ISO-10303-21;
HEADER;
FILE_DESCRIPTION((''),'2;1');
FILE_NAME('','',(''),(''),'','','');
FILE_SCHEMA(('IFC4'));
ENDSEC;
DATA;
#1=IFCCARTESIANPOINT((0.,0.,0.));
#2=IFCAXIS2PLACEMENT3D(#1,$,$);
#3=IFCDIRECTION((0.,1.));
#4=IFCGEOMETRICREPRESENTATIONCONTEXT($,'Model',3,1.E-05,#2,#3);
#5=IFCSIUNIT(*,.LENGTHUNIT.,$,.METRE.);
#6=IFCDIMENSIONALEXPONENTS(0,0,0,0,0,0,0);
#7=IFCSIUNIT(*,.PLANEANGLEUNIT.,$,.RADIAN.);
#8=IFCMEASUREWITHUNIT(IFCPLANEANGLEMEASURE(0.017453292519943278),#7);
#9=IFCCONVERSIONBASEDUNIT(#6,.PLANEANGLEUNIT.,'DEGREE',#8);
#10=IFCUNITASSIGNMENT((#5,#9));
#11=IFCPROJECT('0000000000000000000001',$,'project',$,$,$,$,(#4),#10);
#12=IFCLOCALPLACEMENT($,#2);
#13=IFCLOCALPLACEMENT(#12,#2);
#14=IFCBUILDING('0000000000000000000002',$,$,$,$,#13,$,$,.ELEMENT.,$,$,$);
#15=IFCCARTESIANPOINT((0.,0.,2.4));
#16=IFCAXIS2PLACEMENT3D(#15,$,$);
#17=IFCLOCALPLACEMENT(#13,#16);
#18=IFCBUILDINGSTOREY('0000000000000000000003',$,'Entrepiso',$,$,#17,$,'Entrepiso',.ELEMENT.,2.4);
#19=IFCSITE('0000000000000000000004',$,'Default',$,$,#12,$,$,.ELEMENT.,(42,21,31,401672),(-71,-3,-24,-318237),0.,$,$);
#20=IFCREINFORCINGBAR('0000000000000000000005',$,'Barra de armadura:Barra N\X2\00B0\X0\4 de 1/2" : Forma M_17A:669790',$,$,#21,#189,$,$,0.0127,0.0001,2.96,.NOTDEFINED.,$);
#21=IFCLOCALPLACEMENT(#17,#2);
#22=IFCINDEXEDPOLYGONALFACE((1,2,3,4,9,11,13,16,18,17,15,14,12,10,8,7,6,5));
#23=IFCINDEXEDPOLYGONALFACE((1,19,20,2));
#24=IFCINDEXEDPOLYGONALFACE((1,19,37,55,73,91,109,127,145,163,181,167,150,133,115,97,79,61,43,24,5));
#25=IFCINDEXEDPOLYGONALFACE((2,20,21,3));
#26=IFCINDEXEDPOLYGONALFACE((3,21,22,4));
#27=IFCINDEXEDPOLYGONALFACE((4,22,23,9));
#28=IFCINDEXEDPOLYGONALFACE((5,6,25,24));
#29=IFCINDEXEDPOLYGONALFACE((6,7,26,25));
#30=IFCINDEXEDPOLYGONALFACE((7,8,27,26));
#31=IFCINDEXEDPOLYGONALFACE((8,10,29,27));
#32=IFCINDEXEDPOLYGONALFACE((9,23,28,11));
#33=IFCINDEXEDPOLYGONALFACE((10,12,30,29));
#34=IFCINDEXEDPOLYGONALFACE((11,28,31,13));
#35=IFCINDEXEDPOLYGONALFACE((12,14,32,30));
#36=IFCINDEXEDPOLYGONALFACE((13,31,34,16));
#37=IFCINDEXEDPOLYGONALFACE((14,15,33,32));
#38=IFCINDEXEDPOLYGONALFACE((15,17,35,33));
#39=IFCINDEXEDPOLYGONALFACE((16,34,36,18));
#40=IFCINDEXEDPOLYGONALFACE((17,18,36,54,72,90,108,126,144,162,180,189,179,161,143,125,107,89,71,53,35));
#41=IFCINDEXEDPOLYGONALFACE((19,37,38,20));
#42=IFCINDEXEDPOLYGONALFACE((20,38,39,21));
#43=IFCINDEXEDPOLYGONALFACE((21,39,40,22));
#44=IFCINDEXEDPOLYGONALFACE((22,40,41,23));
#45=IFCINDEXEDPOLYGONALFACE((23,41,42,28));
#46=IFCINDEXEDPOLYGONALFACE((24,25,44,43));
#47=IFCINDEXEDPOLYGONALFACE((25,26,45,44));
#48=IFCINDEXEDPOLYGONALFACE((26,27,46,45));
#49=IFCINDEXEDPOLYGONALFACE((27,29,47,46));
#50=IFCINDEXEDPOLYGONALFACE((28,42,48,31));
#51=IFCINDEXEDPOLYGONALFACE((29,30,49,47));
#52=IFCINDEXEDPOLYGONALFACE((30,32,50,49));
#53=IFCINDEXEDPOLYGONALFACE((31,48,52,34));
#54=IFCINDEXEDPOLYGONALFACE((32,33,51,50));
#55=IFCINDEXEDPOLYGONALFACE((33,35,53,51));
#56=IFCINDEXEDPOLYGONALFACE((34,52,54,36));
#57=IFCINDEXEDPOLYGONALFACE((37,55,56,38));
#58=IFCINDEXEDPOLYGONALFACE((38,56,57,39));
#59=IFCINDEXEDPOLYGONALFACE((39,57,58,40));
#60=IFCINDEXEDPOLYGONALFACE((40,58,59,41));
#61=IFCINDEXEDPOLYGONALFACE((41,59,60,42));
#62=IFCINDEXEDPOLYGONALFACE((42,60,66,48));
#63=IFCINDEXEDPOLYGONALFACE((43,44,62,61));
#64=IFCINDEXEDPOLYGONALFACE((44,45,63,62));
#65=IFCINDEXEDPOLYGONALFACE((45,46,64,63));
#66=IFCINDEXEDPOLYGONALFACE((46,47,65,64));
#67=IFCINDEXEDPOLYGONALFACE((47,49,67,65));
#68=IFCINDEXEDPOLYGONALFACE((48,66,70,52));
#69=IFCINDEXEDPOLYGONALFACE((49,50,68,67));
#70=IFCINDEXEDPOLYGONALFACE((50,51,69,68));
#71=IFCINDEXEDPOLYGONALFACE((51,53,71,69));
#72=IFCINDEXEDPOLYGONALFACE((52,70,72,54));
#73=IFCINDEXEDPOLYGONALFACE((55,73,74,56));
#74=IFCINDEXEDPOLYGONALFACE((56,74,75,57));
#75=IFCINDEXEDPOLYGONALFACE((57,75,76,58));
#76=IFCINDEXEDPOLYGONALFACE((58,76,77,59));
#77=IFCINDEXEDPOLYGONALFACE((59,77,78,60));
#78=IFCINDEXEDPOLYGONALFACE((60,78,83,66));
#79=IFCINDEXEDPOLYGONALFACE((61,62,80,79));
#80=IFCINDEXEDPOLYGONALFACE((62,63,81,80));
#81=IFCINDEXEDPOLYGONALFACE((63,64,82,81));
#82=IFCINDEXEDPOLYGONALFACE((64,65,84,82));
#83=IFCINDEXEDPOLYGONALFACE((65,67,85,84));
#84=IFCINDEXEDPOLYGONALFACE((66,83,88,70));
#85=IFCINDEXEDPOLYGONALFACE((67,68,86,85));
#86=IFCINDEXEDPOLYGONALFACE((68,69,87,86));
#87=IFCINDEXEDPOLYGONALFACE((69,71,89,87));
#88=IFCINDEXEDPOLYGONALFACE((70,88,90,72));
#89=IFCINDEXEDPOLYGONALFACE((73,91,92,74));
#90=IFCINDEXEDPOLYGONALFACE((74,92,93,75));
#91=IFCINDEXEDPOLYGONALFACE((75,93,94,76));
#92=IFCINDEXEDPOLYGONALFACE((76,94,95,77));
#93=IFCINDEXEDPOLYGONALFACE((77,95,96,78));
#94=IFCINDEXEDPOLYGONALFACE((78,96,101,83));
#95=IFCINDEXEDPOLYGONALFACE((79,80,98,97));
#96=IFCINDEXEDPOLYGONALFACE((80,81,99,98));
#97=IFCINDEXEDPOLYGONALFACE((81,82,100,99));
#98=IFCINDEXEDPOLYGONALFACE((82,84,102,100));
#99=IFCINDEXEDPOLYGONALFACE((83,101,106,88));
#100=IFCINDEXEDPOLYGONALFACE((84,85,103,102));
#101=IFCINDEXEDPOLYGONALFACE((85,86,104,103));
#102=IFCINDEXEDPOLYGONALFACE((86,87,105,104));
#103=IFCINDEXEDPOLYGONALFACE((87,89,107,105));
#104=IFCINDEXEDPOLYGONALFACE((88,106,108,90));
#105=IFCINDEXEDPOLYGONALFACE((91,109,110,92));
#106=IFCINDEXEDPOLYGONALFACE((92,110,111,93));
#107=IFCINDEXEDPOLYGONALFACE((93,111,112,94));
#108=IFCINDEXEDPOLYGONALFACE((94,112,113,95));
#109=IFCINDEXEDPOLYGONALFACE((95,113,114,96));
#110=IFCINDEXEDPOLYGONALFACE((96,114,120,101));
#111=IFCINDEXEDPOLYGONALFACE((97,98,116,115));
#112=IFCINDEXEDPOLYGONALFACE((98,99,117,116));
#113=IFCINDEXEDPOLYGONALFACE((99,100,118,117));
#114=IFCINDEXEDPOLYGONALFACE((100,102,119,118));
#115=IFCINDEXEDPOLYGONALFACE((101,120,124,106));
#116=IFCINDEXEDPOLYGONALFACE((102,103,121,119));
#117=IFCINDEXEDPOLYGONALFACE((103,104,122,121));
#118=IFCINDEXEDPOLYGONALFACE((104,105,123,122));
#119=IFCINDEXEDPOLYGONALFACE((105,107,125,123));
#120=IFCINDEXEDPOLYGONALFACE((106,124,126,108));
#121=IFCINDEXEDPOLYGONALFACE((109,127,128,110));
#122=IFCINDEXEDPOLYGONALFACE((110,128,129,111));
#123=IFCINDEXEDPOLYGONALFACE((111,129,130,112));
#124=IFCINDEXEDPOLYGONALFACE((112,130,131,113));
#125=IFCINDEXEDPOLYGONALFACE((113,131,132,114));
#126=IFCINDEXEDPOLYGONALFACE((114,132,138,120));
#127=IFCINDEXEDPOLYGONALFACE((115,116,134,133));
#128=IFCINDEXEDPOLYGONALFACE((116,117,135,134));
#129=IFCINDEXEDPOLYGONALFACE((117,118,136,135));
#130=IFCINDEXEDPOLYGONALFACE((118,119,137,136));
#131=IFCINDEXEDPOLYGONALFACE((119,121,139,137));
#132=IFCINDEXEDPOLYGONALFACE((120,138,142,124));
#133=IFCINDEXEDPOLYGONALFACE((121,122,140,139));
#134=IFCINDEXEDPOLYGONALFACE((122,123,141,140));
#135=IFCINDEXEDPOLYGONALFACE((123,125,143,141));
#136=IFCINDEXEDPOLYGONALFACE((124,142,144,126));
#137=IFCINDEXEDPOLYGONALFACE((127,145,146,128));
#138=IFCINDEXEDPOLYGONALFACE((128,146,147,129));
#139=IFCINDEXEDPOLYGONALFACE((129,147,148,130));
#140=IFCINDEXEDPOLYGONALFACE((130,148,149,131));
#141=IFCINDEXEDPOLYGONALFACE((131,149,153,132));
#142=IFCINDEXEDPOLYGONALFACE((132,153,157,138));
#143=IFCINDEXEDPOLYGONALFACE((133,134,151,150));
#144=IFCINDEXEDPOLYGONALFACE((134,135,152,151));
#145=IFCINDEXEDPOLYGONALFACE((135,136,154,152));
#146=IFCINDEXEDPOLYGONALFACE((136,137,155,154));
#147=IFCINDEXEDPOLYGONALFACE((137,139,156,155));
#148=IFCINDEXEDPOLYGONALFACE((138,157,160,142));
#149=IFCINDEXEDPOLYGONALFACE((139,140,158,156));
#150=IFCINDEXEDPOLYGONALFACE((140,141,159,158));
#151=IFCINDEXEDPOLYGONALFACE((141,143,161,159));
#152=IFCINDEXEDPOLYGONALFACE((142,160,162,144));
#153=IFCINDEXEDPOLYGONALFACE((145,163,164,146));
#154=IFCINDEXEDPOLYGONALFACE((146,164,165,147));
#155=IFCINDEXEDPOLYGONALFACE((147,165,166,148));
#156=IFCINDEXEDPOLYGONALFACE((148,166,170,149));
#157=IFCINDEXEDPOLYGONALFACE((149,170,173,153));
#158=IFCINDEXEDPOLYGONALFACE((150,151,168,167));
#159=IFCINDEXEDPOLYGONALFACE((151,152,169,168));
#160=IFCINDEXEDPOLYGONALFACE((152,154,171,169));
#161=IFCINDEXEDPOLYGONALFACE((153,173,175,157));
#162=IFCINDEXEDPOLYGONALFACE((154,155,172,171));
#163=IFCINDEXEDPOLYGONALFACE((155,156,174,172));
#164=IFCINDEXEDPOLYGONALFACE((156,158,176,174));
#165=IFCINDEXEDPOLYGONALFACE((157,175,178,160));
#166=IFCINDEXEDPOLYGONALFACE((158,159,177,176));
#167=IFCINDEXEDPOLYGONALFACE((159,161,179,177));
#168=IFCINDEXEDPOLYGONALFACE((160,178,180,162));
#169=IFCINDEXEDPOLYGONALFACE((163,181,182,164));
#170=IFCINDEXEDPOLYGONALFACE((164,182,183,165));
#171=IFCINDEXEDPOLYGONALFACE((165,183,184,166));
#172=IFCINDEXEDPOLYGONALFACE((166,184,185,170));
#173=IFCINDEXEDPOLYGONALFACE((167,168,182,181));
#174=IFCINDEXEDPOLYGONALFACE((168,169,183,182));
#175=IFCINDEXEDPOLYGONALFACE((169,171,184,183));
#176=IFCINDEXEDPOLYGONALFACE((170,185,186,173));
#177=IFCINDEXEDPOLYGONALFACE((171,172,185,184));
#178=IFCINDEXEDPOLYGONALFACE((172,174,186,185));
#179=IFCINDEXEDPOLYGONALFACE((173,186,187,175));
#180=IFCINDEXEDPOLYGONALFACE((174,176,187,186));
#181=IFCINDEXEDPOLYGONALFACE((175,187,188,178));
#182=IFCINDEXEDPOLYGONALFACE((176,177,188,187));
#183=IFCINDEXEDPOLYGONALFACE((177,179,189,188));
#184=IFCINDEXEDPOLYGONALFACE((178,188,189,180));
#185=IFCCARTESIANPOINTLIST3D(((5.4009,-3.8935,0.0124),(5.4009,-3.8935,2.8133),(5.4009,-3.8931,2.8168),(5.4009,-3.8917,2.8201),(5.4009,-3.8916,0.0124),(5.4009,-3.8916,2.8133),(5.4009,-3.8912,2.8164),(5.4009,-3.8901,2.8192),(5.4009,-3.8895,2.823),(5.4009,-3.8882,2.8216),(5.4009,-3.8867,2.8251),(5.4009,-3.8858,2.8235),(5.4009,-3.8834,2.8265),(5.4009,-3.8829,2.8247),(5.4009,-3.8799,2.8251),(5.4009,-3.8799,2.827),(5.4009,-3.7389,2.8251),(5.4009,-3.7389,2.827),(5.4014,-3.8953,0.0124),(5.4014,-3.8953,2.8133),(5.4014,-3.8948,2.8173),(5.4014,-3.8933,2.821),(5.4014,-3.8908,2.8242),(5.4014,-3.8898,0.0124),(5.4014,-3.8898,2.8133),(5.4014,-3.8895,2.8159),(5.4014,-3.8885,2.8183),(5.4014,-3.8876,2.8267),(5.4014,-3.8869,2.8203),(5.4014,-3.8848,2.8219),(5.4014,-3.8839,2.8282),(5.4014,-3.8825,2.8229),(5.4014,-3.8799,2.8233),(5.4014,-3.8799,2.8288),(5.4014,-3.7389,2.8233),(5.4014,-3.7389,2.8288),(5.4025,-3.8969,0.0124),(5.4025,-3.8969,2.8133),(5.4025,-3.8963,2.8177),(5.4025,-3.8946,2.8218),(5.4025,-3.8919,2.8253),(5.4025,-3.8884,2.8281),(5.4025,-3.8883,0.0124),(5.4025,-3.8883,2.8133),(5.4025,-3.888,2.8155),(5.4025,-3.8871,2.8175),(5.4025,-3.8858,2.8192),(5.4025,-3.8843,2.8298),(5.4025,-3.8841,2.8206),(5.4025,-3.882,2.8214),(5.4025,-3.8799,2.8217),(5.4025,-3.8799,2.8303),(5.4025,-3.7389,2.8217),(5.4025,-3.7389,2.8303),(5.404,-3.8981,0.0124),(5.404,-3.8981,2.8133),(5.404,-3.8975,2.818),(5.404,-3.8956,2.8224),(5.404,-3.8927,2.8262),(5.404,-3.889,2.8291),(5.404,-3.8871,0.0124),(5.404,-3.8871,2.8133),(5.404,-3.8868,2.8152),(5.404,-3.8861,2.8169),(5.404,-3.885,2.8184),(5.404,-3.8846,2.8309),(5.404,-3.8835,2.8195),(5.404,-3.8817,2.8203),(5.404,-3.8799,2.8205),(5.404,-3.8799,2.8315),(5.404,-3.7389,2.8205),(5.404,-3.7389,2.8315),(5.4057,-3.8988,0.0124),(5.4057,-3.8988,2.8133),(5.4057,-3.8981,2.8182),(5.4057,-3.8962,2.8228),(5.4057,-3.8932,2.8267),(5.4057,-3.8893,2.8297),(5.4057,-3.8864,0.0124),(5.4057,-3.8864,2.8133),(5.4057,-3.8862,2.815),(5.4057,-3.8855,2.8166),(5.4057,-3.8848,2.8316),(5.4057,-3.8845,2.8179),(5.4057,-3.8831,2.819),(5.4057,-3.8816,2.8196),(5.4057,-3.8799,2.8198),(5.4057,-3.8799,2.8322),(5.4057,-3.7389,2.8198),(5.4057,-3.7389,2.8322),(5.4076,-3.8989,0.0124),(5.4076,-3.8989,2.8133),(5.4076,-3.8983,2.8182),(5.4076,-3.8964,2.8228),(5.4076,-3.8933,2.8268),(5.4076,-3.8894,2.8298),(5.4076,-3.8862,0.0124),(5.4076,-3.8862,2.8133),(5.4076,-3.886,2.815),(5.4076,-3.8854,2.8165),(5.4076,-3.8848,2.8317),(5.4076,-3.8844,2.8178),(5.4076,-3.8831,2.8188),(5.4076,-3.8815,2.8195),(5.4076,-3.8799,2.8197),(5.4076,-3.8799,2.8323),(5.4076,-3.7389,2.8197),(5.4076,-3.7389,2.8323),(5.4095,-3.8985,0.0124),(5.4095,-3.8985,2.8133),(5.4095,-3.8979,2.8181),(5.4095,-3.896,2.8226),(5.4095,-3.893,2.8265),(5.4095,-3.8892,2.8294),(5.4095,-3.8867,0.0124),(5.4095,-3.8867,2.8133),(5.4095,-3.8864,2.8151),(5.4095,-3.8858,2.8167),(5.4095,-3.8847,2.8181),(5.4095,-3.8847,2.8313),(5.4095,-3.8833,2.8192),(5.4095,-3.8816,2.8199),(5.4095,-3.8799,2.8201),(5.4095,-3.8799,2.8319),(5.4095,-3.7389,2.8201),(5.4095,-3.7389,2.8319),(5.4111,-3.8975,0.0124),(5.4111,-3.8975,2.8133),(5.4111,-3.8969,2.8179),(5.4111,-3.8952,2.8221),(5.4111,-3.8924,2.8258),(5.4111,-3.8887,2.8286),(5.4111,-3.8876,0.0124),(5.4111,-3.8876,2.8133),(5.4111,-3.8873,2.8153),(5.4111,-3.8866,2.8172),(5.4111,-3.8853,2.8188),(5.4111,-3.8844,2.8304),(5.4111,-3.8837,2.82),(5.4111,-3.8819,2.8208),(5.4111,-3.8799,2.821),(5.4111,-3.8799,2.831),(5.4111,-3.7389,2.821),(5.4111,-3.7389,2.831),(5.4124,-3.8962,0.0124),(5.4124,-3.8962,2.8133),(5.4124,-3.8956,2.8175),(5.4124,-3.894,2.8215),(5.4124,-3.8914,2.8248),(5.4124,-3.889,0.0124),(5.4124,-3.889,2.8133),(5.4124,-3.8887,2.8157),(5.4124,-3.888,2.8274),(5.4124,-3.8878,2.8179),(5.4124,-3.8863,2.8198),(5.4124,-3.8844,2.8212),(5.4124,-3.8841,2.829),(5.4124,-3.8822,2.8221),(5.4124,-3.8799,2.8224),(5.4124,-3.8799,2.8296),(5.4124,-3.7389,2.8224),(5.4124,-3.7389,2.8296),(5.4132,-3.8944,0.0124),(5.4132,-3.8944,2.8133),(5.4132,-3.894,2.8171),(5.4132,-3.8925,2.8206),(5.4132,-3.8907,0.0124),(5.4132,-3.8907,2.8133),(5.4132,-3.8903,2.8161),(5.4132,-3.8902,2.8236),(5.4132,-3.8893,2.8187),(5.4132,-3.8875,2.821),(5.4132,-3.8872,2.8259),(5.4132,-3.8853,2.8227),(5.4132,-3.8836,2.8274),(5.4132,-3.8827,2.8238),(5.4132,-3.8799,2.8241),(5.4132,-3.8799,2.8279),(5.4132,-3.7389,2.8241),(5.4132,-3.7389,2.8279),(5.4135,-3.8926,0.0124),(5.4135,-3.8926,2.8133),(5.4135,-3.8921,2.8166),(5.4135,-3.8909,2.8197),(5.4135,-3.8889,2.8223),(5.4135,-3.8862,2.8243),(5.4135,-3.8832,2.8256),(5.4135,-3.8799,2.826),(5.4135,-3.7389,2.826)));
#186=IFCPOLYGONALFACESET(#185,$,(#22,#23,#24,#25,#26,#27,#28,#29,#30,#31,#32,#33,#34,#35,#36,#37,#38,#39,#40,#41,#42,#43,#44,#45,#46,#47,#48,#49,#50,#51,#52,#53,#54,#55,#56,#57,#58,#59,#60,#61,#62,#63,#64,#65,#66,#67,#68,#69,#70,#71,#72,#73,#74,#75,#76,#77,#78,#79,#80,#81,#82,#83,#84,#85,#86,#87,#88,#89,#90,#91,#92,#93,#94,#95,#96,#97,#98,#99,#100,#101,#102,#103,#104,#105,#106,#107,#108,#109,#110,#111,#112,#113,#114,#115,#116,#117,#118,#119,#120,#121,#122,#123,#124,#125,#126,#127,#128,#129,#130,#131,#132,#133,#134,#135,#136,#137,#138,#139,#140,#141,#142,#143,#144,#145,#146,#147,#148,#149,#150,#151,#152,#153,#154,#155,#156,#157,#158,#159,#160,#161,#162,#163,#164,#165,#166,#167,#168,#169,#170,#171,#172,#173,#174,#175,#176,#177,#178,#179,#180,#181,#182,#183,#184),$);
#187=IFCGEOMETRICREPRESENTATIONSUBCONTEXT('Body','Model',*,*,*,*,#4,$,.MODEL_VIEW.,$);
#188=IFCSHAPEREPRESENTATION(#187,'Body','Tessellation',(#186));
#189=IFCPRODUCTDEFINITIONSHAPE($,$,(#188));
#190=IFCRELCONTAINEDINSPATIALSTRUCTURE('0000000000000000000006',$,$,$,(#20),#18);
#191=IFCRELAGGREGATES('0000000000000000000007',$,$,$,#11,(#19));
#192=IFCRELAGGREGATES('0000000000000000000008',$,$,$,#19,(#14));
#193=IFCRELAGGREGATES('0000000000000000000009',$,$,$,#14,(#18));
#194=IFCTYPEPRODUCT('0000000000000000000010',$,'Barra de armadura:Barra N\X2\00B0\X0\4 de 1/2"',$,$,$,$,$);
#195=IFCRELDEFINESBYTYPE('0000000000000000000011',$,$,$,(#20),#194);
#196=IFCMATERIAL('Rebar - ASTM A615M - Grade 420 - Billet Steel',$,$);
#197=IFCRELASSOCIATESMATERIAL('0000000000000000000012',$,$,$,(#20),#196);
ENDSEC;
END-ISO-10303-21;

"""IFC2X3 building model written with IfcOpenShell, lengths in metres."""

from ifc_helpers import new_model, entity, si_unit, converted_unit, direction, frame, origin, place, context, subcontext, project, spatial, material, type_object, element, save


model = new_model("IFC2X3")

# Units and contexts
model_context = context("Model", 3, precision=1e-05, world=origin(), true_north=direction((0.0, 1.0)))
body_context = subcontext(model_context, "Body", "Model", "MODEL_VIEW")
ifc_project = project(units=[si_unit("LENGTHUNIT", "METRE"), converted_unit("PLANEANGLEUNIT", "DEGREE", entity("IfcPlaneAngleMeasure", 0.017453292519943278), si_unit("PLANEANGLEUNIT", "RADIAN"), dimensions=[0, 0, 0, 0, 0, 0, 0])], contexts=[model_context])

# Site, building, storey
site_placement = place(None, origin())
site = spatial("IfcSite", under=ifc_project, at=site_placement, Name="Default", CompositionType="ELEMENT", RefLatitude=(42, 21, 31, 401672), RefLongitude=(-71, -3, -24, -318237), RefElevation=0.0)
building_placement = place(site_placement, origin())
building = spatial("IfcBuilding", under=site, at=building_placement, CompositionType="ELEMENT")
storey_placement = place(building_placement, frame((0.0, 0.0, 2.4)))
storey = spatial("IfcBuildingStorey", under=building, at=storey_placement, Name="Entrepiso", LongName="Entrepiso", CompositionType="ELEMENT", Elevation=2.4)

# Reinforcing bar
ifc_material = material(Name="Rebar - ASTM A615M - Grade 420 - Billet Steel")
type_product_1 = type_object("IfcTypeProduct", Name="Barra de armadura:Barra N°4 de 1/2\"")
reinforcing_bar_1_placement = place(storey_placement, origin())
element("IfcReinforcingBar", 1, at=reinforcing_bar_1_placement, inside=storey, type_object=type_product_1, material=ifc_material, Name="Barra de armadura:Barra N°4 de 1/2\" : Forma M_17A:669790", BarLength=2.96, BarRole="NOTDEFINED", CrossSectionArea=0.0001, NominalDiameter=0.0127, context=body_context, shape_type="AdvancedSweptSolid", body=[
    entity("IfcSweptDiskSolid", entity("IfcCompositeCurve", [entity("IfcCompositeCurveSegment", "CONTINUOUS", True, entity("IfcPolyline", [entity("IfcCartesianPoint", [5.4071, -3.8926, 0.0124]), entity("IfcCartesianPoint", [5.4071, -3.8926, 2.8133])])), entity("IfcCompositeCurveSegment", "CONTINUOUS", True, entity("IfcTrimmedCurve", entity("IfcCircle", entity("IfcAxis2Placement3D", entity("IfcCartesianPoint", [5.4071, -3.8799, 2.8133]), entity("IfcDirection", [-1.0, 0.0, 0.0]), entity("IfcDirection", [0.0, 0.0, 1.0])), 0.0127), [entity("IfcParameterValue", 270.0)], [entity("IfcParameterValue", 360.0)], True, "PARAMETER")), entity("IfcCompositeCurveSegment", "CONTINUOUS", True, entity("IfcPolyline", [entity("IfcCartesianPoint", [5.4071, -3.8799, 2.826]), entity("IfcCartesianPoint", [5.4071, -3.7389, 2.826])]))], False), 0.0063, None, 0.0, 92.0),
])

save(model, "model.ifc")
